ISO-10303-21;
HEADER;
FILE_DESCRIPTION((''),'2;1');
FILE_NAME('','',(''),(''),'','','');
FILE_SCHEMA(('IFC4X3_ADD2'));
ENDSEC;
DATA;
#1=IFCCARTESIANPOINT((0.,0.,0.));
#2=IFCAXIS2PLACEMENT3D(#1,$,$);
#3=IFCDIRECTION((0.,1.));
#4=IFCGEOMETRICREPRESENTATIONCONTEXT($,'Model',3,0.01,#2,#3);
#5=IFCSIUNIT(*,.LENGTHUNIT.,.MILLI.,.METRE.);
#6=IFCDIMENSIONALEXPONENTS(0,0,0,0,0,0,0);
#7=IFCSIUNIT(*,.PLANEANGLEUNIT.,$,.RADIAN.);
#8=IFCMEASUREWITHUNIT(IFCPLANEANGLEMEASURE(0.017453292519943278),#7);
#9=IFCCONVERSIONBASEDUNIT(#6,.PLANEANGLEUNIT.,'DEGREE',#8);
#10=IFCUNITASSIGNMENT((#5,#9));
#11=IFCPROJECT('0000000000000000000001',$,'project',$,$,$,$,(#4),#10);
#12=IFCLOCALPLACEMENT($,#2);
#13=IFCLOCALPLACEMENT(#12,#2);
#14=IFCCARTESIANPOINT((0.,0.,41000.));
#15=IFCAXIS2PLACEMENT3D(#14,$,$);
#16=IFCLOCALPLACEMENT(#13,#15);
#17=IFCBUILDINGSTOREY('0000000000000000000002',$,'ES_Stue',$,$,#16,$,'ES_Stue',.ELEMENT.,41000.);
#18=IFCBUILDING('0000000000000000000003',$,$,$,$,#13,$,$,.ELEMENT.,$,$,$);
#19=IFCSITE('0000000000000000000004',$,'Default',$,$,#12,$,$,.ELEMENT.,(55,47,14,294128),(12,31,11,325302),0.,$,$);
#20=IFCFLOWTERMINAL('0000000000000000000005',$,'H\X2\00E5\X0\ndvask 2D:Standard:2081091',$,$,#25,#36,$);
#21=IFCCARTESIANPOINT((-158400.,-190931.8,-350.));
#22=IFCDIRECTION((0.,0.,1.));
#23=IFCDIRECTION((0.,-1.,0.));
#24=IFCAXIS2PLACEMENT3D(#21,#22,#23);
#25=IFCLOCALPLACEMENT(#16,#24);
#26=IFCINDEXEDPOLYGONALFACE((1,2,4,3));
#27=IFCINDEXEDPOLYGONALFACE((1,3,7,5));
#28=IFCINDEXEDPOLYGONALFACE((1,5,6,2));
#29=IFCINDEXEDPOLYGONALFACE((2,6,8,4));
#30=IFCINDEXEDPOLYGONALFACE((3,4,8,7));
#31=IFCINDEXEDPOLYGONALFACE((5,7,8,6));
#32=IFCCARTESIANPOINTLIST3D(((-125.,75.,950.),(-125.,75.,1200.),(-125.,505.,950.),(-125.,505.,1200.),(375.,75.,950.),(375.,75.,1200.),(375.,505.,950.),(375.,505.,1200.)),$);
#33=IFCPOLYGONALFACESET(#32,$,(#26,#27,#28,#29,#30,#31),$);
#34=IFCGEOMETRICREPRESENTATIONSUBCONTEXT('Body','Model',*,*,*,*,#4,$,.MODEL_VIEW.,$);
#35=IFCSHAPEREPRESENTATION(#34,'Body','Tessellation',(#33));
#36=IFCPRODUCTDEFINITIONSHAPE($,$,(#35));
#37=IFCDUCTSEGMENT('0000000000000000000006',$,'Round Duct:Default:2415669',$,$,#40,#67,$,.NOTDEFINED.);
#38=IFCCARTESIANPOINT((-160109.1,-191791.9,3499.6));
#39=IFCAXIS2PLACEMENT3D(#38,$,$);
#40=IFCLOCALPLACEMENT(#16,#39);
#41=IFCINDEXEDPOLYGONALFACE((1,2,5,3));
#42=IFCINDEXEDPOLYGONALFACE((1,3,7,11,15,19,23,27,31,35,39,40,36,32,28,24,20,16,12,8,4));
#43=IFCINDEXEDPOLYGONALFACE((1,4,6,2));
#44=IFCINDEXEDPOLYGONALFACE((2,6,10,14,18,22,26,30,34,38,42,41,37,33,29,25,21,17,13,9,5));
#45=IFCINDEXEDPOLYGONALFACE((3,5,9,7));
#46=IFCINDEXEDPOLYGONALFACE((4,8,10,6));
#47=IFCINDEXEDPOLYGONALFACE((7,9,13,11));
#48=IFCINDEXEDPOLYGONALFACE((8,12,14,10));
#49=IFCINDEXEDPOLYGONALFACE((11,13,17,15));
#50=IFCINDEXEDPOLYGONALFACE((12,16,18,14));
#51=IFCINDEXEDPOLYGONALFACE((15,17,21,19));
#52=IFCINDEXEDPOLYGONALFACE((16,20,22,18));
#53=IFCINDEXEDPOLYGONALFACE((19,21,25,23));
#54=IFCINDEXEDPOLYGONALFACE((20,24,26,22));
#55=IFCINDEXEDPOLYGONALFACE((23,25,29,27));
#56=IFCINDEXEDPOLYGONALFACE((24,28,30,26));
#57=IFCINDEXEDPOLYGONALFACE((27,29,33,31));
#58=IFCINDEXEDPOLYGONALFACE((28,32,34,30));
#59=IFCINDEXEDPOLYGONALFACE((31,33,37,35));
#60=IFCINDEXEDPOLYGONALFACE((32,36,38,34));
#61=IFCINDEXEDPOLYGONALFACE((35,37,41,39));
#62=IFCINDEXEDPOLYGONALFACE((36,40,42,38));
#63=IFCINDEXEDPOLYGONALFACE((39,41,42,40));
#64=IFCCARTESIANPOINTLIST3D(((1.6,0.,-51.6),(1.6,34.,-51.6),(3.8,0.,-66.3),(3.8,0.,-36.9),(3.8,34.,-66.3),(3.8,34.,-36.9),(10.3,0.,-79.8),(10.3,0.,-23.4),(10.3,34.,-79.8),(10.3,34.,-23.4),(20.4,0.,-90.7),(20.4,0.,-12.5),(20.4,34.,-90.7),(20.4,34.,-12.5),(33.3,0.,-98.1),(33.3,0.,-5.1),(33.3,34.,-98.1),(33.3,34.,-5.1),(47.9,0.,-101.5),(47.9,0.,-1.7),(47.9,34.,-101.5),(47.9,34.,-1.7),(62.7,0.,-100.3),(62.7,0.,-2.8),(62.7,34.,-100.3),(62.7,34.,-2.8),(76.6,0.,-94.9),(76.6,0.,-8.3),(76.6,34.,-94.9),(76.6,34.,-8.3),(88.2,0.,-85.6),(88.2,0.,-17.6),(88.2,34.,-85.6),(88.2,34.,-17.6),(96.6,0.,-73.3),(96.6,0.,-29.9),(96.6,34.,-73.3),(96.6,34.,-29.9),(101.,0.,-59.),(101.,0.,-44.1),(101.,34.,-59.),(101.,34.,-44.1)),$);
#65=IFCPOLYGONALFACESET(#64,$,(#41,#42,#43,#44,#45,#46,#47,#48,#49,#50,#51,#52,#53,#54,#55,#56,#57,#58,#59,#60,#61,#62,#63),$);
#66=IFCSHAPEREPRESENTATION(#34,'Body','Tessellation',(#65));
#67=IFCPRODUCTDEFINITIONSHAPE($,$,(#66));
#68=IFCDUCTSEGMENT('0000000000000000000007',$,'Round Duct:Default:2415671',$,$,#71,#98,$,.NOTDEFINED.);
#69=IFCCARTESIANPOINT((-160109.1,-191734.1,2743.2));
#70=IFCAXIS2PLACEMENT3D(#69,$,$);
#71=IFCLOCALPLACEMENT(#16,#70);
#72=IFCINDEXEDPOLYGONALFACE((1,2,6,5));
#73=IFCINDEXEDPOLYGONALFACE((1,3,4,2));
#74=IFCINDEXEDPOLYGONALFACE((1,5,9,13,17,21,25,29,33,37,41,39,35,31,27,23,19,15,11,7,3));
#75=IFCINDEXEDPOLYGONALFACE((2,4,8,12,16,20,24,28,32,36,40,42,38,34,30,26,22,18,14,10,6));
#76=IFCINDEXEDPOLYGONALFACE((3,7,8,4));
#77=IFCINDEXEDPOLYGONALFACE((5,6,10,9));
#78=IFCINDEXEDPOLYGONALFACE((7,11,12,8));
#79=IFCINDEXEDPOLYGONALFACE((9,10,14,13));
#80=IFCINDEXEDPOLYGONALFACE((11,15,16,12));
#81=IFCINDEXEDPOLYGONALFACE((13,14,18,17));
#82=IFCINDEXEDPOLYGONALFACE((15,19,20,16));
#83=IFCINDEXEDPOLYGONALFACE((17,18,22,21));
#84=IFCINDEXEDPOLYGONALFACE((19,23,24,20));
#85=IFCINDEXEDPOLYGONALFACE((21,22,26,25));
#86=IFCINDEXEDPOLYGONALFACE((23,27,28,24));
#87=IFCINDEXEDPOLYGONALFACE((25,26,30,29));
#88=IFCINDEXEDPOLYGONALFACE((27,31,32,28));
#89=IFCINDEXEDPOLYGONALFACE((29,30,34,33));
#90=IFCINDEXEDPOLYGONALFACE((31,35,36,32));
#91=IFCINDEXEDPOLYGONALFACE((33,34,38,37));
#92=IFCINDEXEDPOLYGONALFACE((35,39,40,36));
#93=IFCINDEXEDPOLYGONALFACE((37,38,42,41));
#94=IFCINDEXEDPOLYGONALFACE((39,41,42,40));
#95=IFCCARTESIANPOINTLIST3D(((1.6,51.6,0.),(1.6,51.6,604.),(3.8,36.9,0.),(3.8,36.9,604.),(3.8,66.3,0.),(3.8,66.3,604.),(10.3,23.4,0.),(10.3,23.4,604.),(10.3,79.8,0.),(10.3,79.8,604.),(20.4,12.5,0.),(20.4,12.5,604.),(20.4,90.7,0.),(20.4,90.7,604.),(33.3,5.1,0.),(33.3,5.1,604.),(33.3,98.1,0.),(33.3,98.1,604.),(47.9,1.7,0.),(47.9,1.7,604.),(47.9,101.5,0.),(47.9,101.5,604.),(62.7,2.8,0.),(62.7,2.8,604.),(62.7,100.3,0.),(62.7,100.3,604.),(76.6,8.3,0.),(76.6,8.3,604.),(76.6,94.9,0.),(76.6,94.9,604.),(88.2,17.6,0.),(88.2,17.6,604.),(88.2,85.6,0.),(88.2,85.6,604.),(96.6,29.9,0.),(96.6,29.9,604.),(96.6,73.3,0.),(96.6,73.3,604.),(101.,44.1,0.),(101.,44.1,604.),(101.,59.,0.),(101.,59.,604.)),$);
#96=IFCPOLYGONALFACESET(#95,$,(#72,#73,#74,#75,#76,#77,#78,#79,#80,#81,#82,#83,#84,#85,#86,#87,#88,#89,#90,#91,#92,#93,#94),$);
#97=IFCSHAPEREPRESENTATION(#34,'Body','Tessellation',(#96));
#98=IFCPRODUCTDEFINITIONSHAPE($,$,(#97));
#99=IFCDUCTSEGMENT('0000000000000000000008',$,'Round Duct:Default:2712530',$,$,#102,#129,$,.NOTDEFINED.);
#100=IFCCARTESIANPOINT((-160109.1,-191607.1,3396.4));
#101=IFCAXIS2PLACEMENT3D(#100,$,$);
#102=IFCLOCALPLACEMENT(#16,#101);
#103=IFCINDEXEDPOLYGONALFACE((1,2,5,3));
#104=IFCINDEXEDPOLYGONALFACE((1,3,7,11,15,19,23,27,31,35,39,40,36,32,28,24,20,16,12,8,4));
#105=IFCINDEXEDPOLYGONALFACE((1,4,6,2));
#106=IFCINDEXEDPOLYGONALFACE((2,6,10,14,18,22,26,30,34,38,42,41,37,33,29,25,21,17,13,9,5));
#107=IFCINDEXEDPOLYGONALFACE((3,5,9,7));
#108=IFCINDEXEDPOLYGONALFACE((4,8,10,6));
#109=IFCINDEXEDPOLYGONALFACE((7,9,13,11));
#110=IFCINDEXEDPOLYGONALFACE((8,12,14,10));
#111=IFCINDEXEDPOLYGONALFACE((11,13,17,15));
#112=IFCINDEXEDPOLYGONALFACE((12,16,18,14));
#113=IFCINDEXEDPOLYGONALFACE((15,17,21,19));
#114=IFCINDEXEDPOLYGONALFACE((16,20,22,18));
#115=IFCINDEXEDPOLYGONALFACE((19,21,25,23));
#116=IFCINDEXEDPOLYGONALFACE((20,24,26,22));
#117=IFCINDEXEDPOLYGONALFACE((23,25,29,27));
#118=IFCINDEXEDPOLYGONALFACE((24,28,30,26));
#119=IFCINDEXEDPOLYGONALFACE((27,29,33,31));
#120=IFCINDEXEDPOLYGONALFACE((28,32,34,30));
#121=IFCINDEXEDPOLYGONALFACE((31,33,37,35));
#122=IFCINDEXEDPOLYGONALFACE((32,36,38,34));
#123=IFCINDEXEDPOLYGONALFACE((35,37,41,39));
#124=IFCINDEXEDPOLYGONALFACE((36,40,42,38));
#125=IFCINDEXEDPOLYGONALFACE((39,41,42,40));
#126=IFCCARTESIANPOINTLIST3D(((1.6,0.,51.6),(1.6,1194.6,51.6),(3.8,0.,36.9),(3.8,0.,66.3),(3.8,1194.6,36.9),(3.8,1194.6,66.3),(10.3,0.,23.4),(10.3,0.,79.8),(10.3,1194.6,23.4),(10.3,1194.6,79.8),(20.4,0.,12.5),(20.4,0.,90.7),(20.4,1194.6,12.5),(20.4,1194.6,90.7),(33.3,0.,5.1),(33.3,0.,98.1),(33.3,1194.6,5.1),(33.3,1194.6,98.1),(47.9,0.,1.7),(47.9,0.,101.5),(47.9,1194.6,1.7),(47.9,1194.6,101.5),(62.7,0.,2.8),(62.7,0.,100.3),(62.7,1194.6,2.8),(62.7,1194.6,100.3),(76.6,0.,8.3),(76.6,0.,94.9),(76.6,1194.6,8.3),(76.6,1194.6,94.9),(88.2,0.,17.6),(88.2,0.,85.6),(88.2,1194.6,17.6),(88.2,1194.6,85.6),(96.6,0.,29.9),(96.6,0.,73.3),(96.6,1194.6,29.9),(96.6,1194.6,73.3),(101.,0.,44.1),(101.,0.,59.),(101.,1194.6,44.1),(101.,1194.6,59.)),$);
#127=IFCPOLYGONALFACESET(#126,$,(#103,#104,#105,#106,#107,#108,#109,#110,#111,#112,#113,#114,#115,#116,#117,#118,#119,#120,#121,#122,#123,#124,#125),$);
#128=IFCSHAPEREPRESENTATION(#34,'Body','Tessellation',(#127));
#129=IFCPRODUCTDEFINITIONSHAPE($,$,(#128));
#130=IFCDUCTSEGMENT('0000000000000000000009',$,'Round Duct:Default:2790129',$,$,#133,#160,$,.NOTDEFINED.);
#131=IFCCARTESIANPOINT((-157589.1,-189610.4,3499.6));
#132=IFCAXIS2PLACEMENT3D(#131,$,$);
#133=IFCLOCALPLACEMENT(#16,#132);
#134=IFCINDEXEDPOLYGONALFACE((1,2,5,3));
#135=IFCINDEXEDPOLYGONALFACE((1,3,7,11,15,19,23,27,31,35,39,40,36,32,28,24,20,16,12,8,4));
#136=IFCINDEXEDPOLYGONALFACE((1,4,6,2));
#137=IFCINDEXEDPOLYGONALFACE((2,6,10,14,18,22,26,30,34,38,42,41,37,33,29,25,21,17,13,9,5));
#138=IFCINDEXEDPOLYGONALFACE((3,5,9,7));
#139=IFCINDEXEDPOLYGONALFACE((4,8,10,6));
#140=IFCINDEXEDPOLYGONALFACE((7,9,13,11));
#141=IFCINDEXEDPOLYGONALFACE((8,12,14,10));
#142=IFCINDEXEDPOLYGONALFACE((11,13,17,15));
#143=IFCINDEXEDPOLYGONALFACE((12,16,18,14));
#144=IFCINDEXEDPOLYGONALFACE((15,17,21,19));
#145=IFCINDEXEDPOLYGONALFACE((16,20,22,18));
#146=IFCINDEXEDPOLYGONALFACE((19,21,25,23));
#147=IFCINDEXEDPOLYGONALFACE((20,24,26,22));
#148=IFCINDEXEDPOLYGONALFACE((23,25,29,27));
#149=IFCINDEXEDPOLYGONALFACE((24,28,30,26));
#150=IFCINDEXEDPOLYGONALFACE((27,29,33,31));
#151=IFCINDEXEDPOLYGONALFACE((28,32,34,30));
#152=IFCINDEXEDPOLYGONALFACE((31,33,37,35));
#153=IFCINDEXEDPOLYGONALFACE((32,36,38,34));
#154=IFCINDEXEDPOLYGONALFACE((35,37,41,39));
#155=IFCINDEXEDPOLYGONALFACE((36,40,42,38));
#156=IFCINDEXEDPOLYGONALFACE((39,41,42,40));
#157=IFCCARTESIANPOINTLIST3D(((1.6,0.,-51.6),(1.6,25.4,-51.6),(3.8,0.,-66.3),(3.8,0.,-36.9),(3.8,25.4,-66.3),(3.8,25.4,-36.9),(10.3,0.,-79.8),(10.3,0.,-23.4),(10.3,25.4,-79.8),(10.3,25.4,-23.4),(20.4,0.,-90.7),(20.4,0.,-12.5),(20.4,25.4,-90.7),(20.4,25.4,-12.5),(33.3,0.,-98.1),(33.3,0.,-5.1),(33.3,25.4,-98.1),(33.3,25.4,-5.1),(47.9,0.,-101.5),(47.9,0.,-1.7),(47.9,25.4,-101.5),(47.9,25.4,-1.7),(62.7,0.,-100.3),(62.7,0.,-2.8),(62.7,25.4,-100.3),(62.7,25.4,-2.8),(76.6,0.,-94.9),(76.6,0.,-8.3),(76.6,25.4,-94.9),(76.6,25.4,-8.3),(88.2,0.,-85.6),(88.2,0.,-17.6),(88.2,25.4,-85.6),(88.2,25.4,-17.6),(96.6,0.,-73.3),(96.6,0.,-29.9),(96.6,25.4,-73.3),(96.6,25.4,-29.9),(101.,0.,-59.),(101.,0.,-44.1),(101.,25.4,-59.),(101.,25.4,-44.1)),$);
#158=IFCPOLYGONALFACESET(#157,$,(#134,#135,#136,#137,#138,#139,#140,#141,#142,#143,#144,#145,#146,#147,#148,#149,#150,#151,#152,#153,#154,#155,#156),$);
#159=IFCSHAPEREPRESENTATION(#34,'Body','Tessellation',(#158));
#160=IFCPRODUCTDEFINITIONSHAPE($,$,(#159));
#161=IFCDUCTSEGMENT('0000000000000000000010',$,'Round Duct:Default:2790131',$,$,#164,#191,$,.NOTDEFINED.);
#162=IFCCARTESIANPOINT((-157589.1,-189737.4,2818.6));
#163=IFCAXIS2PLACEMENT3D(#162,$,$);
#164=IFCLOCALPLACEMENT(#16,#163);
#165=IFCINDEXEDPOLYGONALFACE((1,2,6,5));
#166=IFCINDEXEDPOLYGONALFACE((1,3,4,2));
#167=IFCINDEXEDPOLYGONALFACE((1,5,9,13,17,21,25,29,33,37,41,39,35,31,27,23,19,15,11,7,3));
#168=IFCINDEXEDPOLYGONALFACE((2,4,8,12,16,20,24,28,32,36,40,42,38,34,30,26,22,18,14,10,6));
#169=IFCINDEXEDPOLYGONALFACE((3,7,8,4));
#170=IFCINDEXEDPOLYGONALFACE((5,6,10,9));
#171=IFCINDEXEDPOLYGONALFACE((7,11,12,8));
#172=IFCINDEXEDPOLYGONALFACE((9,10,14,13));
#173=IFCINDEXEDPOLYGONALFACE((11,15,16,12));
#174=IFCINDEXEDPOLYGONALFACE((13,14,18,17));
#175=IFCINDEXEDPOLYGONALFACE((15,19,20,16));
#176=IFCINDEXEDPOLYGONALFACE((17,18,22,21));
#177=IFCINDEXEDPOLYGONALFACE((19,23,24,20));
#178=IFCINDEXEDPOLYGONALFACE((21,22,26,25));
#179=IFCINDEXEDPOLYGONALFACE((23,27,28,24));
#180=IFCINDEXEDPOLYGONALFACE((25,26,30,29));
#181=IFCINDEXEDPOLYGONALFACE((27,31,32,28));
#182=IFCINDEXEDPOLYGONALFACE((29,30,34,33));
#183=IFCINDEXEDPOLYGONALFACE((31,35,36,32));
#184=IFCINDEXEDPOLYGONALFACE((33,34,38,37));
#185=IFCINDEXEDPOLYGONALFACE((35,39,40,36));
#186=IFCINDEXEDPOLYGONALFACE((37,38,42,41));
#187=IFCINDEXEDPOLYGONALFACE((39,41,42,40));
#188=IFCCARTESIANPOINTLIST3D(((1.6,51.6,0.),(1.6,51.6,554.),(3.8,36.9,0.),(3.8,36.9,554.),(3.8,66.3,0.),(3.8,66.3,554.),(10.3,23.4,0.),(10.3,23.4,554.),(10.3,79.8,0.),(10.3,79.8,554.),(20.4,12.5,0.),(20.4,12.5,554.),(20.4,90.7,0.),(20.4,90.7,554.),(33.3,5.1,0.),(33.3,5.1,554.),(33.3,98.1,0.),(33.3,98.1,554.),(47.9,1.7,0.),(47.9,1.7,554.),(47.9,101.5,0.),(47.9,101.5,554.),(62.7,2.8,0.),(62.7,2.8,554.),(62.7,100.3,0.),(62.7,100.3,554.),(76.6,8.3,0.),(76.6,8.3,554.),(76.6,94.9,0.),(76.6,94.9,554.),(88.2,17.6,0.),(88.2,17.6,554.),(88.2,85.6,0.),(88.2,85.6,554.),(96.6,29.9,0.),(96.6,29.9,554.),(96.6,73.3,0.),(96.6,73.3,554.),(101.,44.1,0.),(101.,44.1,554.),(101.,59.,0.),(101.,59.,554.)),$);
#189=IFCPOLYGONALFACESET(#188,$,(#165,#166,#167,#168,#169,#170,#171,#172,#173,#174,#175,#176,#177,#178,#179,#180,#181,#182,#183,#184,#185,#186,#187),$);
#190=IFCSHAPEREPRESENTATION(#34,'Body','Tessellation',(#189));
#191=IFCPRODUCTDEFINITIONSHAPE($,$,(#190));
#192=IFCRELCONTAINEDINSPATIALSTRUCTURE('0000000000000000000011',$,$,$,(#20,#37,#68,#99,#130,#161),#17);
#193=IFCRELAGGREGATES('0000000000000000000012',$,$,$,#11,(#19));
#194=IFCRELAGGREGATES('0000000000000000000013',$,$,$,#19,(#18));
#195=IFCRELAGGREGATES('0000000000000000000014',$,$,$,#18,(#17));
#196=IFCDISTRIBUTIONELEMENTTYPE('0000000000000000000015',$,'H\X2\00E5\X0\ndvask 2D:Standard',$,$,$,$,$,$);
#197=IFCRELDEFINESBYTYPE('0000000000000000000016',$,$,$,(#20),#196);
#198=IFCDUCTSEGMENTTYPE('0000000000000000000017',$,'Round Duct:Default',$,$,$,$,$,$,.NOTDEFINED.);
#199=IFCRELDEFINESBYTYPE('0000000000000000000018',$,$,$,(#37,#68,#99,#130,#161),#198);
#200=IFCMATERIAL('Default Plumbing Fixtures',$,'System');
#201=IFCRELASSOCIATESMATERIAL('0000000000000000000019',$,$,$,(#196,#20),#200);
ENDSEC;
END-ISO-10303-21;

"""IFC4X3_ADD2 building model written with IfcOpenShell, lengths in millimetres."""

from ifc_helpers import new_model, entity, si_unit, converted_unit, direction, frame, frame_2d, origin, origin_2d_with_axis, place, context, subcontext, project, spatial, rectangle, circle, extrude, source, transform, mapped, material, type_object, type_shapes, element, save


model = new_model("IFC4X3_ADD2")

# Units and contexts
model_context = context("Model", 3, precision=0.01, world=origin(), true_north=direction((0.0, 1.0)))
body_context = subcontext(model_context, "Body", "Model", "MODEL_VIEW")
ifc_project = project(units=[si_unit("LENGTHUNIT", "METRE", prefix="MILLI"), converted_unit("PLANEANGLEUNIT", "DEGREE", entity("IfcPlaneAngleMeasure", 0.017453292519943278), si_unit("PLANEANGLEUNIT", "RADIAN"), dimensions=[0, 0, 0, 0, 0, 0, 0])], contexts=[model_context])

# Site, building, storey
site_placement = place(None, origin())
site = spatial("IfcSite", under=ifc_project, at=site_placement, Name="Default", CompositionType="ELEMENT", RefLatitude=(55, 47, 14, 294128), RefLongitude=(12, 31, 11, 325302), RefElevation=0.0)
building_placement = place(site_placement, origin())
building = spatial("IfcBuilding", under=site, at=building_placement, CompositionType="ELEMENT")
storey_placement = place(building_placement, frame((0.0, 0.0, 41000.0)))
storey = spatial("IfcBuildingStorey", under=building, at=storey_placement, Name="ES_Stue", LongName="ES_Stue", CompositionType="ELEMENT", Elevation=41000.0)

# Flow terminal
ifc_material_1 = material(Name="Default Plumbing Fixtures", Category="System")
distribution_element_type_1 = type_object("IfcDistributionElementType", Name="Håndvask 2D:Standard", material=ifc_material_1)
shared_shape_1 = source(origin(), body_context, "Body", "SweptSolid", [
    extrude(rectangle(XDim=500.0, YDim=430.0, at=frame_2d((0.0, 0.0), x_axis=(1.0, 0.0))), frame((125.0, 290.0, 950.0), z_axis=(0.0, 0.0, 1.0), x_axis=(-1.0, 0.0, 0.0)), (0.0, 0.0, 1.0), 250.0),
])
type_shapes(distribution_element_type_1, [shared_shape_1])
for number, where, z_axis, x_axis, name in (
    (1, (-158400.0, -190931.8, -350.0), (0.0, 0.0, 1.0), (0.0, -1.0, 0.0), "Håndvask 2D:Standard:2081091"),
):
    element("IfcFlowTerminal", number, at=place(storey_placement, frame(where, z_axis=z_axis, x_axis=x_axis)), inside=storey, type_object=distribution_element_type_1, material=ifc_material_1, Name=name, context=body_context, shape_type="MappedRepresentation", body=[
        mapped(shared_shape_1, transform((0.0, 0.0, 0.0), scale=1.0)),
    ])

# Duct segments
duct_segment_type = type_object("IfcDuctSegmentType", Name="Round Duct:Default", PredefinedType="NOTDEFINED")
duct_segment_1_placement = place(storey_placement, frame((-160109.1, -191791.9, 3499.6)))
element("IfcDuctSegment", 2, at=duct_segment_1_placement, inside=storey, type_object=duct_segment_type, Name="Round Duct:Default:2415669", PredefinedType="NOTDEFINED", context=body_context, shape_type="SweptSolid", body=[
    extrude(circle(Radius=50.0, at=frame_2d((0.0, 0.0), x_axis=(1.0, 0.0))), frame((51.6, 0.0, -51.6), z_axis=(0.0, 1.0, 0.0), x_axis=(-1.0, 0.0, 0.0)), (0.0, 0.0, 1.0), 34.0),
])
duct_segment_2_placement = place(storey_placement, frame((-160109.1, -191734.1, 2743.2)))
element("IfcDuctSegment", 3, at=duct_segment_2_placement, inside=storey, type_object=duct_segment_type, Name="Round Duct:Default:2415671", PredefinedType="NOTDEFINED", context=body_context, shape_type="SweptSolid", body=[
    extrude(circle(Radius=50.0, at=origin_2d_with_axis()), frame((51.6, 51.6, 0.0), z_axis=(0.0, 0.0, 1.0), x_axis=(-1.0, 0.0, 0.0)), (0.0, 0.0, 1.0), 604.0),
])
duct_segment_3_placement = place(storey_placement, frame((-160109.1, -191607.1, 3396.4)))
element("IfcDuctSegment", 4, at=duct_segment_3_placement, inside=storey, type_object=duct_segment_type, Name="Round Duct:Default:2712530", PredefinedType="NOTDEFINED", context=body_context, shape_type="SweptSolid", body=[
    extrude(circle(Radius=50.0, at=origin_2d_with_axis()), frame((51.6, 0.0, 51.6), z_axis=(0.0, 1.0, 0.0), x_axis=(-1.0, 0.0, 0.0)), (0.0, 0.0, 1.0), 1194.6),
])
duct_segment_4_placement = place(storey_placement, frame((-157589.1, -189610.4, 3499.6)))
element("IfcDuctSegment", 5, at=duct_segment_4_placement, inside=storey, type_object=duct_segment_type, Name="Round Duct:Default:2790129", PredefinedType="NOTDEFINED", context=body_context, shape_type="SweptSolid", body=[
    extrude(circle(Radius=50.0, at=origin_2d_with_axis()), frame((51.6, 0.0, -51.6), z_axis=(0.0, 1.0, 0.0), x_axis=(-1.0, 0.0, 0.0)), (0.0, 0.0, 1.0), 25.4),
])
duct_segment_5_placement = place(storey_placement, frame((-157589.1, -189737.4, 2818.6)))
element("IfcDuctSegment", 6, at=duct_segment_5_placement, inside=storey, type_object=duct_segment_type, Name="Round Duct:Default:2790131", PredefinedType="NOTDEFINED", context=body_context, shape_type="SweptSolid", body=[
    extrude(circle(Radius=50.0, at=origin_2d_with_axis()), frame((51.6, 51.6, 0.0), z_axis=(0.0, 0.0, 1.0), x_axis=(-1.0, 0.0, 0.0)), (0.0, 0.0, 1.0), 554.0),
])

save(model, "model.ifc")
